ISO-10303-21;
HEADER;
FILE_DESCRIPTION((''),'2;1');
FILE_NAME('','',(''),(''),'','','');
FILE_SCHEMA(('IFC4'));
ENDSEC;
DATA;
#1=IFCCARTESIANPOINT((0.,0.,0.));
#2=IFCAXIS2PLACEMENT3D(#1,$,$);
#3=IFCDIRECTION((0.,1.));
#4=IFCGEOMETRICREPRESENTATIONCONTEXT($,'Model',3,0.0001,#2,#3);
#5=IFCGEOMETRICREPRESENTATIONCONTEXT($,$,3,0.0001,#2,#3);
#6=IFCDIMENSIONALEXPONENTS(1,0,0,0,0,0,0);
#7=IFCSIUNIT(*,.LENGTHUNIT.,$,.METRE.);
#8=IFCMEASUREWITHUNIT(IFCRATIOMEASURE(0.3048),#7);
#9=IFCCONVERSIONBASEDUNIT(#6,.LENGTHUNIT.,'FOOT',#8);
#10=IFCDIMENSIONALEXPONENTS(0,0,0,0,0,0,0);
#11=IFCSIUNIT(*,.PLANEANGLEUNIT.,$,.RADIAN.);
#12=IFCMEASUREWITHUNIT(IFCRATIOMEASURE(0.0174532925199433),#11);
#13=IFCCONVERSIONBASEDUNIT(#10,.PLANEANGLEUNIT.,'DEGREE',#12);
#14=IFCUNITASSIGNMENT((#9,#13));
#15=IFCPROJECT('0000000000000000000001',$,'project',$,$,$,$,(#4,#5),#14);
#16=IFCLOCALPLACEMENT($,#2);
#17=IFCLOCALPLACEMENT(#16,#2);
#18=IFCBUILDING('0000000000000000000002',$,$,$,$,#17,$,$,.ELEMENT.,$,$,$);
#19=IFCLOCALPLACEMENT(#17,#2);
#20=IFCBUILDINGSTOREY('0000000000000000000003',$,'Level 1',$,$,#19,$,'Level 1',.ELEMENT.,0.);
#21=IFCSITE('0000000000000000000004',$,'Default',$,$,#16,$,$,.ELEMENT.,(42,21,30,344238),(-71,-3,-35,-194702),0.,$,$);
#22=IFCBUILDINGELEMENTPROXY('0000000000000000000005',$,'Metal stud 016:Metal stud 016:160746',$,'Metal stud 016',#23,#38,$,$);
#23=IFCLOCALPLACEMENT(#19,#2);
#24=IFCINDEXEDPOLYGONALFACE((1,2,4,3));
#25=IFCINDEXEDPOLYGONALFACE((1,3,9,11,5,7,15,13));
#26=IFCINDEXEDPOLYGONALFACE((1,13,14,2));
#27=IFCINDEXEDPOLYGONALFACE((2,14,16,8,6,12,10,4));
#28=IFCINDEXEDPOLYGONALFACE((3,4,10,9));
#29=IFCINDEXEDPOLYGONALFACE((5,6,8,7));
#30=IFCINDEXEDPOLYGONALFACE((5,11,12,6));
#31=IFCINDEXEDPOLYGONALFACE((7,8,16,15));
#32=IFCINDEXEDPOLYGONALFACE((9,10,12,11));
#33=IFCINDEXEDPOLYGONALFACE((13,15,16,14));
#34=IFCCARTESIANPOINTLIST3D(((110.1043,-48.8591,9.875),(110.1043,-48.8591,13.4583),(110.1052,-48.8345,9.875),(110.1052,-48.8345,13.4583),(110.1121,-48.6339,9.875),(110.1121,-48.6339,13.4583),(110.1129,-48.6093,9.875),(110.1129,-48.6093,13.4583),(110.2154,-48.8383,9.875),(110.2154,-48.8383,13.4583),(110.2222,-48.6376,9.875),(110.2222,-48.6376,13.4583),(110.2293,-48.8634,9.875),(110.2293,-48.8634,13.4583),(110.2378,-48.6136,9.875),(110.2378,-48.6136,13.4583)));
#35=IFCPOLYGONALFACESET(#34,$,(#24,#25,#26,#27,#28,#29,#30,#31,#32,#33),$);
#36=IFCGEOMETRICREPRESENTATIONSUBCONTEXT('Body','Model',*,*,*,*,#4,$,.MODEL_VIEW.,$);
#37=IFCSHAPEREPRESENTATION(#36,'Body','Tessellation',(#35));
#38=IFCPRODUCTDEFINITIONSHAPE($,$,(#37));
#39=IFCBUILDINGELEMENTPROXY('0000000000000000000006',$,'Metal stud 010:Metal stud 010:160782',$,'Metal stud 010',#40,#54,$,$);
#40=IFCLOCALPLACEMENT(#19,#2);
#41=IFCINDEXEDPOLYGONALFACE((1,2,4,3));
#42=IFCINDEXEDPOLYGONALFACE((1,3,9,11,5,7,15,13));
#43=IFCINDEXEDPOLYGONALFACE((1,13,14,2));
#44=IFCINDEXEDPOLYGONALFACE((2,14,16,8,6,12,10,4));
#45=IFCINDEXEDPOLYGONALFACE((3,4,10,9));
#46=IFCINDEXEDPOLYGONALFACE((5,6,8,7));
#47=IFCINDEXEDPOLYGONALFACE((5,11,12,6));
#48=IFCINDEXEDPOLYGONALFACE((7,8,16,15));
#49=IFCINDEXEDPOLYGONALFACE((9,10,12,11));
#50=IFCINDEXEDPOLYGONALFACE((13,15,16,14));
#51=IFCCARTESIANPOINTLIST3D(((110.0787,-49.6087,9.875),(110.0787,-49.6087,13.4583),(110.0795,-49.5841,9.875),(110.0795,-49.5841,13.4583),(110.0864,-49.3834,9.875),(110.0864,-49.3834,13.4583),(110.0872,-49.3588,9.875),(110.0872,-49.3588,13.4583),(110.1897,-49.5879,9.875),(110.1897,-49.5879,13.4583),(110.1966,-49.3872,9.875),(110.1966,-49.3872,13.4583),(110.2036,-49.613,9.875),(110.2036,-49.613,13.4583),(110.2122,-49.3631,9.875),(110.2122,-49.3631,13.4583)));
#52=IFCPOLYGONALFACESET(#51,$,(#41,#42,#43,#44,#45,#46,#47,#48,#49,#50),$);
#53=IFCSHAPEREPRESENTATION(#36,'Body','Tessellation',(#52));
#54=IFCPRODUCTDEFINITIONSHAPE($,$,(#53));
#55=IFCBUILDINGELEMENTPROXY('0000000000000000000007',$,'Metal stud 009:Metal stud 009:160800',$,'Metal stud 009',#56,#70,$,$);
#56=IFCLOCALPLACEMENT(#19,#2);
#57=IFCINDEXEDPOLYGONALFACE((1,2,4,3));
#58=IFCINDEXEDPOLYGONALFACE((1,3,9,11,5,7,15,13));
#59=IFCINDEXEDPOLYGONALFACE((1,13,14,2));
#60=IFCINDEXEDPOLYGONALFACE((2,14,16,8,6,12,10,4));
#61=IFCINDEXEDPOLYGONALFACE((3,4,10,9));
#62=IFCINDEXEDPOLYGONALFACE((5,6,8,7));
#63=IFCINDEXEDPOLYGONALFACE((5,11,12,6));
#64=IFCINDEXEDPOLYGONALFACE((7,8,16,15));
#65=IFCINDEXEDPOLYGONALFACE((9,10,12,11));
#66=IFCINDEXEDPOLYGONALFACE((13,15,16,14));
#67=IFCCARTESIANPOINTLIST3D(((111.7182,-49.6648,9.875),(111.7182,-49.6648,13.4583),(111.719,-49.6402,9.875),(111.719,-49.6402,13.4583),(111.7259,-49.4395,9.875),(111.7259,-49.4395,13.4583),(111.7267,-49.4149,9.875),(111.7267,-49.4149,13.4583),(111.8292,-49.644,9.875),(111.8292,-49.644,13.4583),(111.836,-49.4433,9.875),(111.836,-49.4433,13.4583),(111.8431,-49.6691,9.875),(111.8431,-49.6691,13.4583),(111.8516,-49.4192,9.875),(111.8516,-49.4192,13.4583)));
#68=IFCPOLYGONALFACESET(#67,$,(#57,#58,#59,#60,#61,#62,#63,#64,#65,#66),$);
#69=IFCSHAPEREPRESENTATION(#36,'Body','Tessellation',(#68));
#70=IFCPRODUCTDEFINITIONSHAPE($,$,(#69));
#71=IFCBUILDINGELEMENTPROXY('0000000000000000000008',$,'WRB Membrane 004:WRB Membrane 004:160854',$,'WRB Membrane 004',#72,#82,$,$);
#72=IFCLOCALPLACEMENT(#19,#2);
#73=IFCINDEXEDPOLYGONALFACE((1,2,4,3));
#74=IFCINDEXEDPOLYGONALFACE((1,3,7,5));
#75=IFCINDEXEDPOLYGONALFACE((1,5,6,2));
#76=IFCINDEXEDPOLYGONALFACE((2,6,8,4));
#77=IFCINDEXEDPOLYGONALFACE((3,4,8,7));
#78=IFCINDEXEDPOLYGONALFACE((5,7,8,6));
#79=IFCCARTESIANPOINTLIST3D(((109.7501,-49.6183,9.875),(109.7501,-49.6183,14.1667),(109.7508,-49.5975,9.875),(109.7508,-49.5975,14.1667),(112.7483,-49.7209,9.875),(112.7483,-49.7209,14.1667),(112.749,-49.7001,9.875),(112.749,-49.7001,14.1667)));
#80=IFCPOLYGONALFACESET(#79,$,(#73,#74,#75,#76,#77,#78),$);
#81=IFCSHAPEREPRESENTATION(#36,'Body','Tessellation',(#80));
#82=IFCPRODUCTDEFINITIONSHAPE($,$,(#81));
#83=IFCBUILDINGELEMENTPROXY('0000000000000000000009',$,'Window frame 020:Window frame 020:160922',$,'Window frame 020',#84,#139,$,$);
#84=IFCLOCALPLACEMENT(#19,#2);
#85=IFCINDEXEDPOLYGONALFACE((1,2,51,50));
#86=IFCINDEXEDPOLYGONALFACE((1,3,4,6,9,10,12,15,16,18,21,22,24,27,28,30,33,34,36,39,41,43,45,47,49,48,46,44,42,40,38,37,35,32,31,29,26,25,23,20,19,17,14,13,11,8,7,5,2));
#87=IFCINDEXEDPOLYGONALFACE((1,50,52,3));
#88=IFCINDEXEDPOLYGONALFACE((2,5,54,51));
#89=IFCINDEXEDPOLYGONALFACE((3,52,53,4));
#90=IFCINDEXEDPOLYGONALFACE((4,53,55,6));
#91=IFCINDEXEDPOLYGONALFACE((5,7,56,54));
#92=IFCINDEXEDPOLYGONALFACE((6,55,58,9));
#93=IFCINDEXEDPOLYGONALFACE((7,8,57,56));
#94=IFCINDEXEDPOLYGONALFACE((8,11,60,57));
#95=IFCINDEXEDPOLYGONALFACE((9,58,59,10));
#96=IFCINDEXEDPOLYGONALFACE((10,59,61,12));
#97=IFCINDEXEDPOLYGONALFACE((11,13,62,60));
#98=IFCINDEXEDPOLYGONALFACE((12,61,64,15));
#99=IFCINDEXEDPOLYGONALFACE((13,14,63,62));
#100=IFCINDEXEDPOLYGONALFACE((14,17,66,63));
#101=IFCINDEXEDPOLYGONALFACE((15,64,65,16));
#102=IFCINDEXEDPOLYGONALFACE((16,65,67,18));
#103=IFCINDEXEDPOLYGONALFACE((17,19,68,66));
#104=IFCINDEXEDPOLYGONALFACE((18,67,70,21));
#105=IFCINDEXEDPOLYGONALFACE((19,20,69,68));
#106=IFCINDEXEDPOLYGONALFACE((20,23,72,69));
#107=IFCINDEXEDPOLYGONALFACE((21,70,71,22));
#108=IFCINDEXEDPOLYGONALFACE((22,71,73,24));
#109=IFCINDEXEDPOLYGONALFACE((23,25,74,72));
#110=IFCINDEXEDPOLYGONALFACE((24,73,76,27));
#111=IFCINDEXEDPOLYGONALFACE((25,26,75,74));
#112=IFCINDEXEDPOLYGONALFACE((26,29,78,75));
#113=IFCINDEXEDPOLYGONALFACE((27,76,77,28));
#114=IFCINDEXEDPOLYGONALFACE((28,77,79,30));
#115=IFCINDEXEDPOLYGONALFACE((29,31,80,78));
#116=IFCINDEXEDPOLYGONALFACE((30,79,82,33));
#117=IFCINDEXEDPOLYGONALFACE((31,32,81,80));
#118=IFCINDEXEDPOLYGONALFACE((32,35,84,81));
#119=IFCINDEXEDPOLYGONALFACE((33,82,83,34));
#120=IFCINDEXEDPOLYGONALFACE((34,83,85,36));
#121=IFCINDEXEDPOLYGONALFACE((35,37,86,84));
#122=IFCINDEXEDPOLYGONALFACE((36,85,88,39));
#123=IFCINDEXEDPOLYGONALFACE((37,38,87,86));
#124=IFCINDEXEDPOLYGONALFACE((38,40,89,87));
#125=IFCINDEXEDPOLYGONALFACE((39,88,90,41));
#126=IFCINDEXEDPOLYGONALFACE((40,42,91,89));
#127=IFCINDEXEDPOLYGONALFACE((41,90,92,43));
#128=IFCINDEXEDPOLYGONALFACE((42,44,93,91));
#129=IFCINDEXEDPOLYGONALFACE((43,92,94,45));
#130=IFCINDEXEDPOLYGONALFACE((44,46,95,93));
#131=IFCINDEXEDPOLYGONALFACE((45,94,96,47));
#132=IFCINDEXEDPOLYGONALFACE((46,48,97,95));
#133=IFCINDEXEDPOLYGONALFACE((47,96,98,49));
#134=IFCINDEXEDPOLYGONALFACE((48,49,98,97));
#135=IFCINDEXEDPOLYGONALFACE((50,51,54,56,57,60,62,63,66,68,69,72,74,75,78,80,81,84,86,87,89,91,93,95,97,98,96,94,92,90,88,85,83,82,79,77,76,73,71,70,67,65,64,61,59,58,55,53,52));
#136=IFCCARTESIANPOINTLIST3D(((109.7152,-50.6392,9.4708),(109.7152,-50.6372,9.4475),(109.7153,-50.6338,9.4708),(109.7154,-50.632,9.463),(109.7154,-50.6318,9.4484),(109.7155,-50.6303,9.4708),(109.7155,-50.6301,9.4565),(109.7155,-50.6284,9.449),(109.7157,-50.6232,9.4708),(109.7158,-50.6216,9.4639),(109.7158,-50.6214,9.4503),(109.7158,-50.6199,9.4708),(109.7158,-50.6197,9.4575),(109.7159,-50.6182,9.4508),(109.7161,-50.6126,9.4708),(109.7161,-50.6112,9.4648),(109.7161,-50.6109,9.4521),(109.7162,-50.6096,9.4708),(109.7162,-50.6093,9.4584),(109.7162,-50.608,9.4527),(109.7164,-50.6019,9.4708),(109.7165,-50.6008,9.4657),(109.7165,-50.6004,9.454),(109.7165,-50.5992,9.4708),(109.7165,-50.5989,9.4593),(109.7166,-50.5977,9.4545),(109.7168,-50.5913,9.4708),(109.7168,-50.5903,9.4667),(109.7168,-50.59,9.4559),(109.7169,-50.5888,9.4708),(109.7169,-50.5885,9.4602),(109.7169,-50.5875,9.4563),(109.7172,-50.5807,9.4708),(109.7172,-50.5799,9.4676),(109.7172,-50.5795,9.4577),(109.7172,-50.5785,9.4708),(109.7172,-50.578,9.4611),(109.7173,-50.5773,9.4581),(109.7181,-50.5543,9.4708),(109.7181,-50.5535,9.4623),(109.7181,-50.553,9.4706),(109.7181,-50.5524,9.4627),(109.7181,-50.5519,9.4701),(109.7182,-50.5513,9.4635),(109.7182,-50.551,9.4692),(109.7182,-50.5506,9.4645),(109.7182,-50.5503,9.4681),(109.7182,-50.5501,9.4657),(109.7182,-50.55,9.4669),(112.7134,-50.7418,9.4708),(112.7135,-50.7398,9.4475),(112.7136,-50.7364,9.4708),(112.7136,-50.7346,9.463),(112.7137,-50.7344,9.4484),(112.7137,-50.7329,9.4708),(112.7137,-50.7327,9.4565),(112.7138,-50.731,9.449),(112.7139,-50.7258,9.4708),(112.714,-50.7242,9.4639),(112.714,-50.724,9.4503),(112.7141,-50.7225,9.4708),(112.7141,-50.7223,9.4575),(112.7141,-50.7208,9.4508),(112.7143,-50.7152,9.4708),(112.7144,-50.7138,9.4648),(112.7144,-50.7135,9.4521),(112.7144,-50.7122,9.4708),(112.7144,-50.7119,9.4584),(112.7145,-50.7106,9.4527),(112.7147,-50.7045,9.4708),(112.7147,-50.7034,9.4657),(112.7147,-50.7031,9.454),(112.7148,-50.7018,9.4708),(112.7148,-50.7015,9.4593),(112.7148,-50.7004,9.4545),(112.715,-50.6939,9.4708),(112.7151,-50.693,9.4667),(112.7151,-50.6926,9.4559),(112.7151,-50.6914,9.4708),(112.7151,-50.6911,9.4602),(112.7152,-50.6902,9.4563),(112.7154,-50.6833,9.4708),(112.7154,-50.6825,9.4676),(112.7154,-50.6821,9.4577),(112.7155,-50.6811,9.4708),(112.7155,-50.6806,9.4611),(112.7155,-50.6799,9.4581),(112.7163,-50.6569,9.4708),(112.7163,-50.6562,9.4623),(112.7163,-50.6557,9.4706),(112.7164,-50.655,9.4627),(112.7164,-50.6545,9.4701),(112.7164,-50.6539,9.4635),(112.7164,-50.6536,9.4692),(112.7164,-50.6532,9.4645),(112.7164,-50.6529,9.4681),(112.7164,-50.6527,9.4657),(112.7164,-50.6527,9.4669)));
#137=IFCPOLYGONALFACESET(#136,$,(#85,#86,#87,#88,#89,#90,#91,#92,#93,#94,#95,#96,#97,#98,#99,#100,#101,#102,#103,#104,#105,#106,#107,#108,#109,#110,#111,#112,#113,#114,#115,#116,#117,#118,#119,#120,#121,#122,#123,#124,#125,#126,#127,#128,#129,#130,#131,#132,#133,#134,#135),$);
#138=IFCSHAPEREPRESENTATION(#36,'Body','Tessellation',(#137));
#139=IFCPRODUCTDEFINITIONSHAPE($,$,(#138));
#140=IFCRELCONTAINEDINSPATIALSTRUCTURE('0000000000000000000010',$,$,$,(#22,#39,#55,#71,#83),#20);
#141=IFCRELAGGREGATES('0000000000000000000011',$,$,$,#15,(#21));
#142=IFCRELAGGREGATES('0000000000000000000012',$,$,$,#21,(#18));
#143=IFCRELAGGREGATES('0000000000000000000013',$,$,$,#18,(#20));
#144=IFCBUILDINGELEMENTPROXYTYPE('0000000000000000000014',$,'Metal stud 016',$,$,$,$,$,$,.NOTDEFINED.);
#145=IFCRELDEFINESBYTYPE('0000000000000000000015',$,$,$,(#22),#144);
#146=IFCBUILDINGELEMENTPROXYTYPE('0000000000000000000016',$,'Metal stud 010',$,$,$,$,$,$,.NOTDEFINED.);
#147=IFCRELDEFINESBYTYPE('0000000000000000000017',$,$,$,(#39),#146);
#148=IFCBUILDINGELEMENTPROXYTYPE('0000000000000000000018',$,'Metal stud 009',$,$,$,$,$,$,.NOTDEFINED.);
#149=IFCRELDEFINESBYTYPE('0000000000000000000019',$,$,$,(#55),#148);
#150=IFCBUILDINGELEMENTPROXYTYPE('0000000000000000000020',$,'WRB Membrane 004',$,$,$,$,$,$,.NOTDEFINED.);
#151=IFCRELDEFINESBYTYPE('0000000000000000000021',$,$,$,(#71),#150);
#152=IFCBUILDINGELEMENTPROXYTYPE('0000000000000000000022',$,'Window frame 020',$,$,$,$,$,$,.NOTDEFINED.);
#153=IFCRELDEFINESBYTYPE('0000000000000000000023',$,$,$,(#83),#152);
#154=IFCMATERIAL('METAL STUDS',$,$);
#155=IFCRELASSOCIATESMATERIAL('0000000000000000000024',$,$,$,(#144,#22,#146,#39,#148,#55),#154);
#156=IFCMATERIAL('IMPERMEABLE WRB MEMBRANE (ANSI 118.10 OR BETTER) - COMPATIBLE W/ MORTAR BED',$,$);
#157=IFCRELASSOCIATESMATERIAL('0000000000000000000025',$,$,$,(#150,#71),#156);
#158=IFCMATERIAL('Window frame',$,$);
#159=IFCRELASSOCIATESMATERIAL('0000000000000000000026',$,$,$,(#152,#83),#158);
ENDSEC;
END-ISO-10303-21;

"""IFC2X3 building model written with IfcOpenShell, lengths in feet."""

from ifc_helpers import new_model, entity, si_unit, converted_unit, direction, frame, frame_2d, origin, origin_2d_with_axis, place, context, subcontext, project, spatial, polyline, circle_curve, parameter, trimmed, segment, composite_curve, rectangle, outline, extrude, source, transform, mapped, material, type_object, type_shapes, element, save


model = new_model("IFC2X3")

# Units and contexts
model_context = context("Model", 3, precision=0.0001, world=origin(), true_north=direction((0.0, 1.0)))
context_of_model = context(None, 3, precision=0.0001, world=origin(), true_north=direction((0.0, 1.0)))
body_context = subcontext(model_context, "Body", "Model", "MODEL_VIEW")
ifc_project = project(units=[converted_unit("LENGTHUNIT", "FOOT", entity("IfcRatioMeasure", 0.3048), si_unit("LENGTHUNIT", "METRE"), dimensions=[1, 0, 0, 0, 0, 0, 0]), converted_unit("PLANEANGLEUNIT", "DEGREE", entity("IfcRatioMeasure", 0.0174532925199433), si_unit("PLANEANGLEUNIT", "RADIAN"), dimensions=[0, 0, 0, 0, 0, 0, 0])], contexts=[model_context, context_of_model])

# Site, building, storey
site_placement = place(None, origin())
site = spatial("IfcSite", under=ifc_project, at=site_placement, Name="Default", CompositionType="ELEMENT", RefLatitude=(42, 21, 30, 344238), RefLongitude=(-71, -3, -35, -194702), RefElevation=0.0)
building_placement = place(site_placement, origin())
building = spatial("IfcBuilding", under=site, at=building_placement, CompositionType="ELEMENT")
storey_placement = place(building_placement, origin())
storey = spatial("IfcBuildingStorey", under=building, at=storey_placement, Name="Level 1", LongName="Level 1", CompositionType="ELEMENT", Elevation=0.0)

# Building element proxies
ifc_material_1 = material(Name="METAL STUDS")
building_element_proxy_type_1 = type_object("IfcBuildingElementProxyType", Name="Metal stud 016", PredefinedType="NOTDEFINED", material=ifc_material_1)
shared_shape_1 = source(origin(), body_context, "Body", "SweptSolid", [
    extrude(outline(polyline([(-0.0662, -0.125), (0.0588, -0.125), (0.0588, -0.1004), (-0.0514, -0.1004), (-0.0514, 0.1004), (0.0588, 0.1004), (0.0588, 0.125), (-0.0662, 0.125), (-0.0662, -0.125)])), frame((110.1674, -48.7362, 9.875), z_axis=(0.0, 0.0, 1.0), x_axis=(-0.999415, 0.034202, 0.0)), (0.0, 0.0, 1.0), 3.5833),
])
type_shapes(building_element_proxy_type_1, [shared_shape_1])
proxy_1_placement = place(storey_placement, origin())
element("IfcBuildingElementProxy", 1, at=proxy_1_placement, inside=storey, type_object=building_element_proxy_type_1, material=ifc_material_1, Name="Metal stud 016:Metal stud 016:160746", ObjectType="Metal stud 016", context=body_context, shape_type="MappedRepresentation", body=[
    mapped(shared_shape_1, transform((0.0, 0.0, 0.0), scale=1.0)),
])
building_element_proxy_type_2 = type_object("IfcBuildingElementProxyType", Name="Metal stud 010", PredefinedType="NOTDEFINED", material=ifc_material_1)
shared_shape_2 = source(origin(), body_context, "Body", "SweptSolid", [
    extrude(outline(polyline([(-0.0662, -0.125), (0.0588, -0.125), (0.0588, -0.1004), (-0.0514, -0.1004), (-0.0514, 0.1004), (0.0588, 0.1004), (0.0588, 0.125), (-0.0662, 0.125), (-0.0662, -0.125)])), frame((110.1417, -49.4858, 9.875), z_axis=(0.0, 0.0, 1.0), x_axis=(-0.999415, 0.034202, 0.0)), (0.0, 0.0, 1.0), 3.5833),
])
type_shapes(building_element_proxy_type_2, [shared_shape_2])
proxy_2_placement = place(storey_placement, origin())
element("IfcBuildingElementProxy", 2, at=proxy_2_placement, inside=storey, type_object=building_element_proxy_type_2, material=ifc_material_1, Name="Metal stud 010:Metal stud 010:160782", ObjectType="Metal stud 010", context=body_context, shape_type="MappedRepresentation", body=[
    mapped(shared_shape_2, transform((0.0, 0.0, 0.0), scale=1.0)),
])
building_element_proxy_type_3 = type_object("IfcBuildingElementProxyType", Name="Metal stud 009", PredefinedType="NOTDEFINED", material=ifc_material_1)
shared_shape_3 = source(origin(), body_context, "Body", "SweptSolid", [
    extrude(outline(polyline([(-0.0662, -0.125), (0.0588, -0.125), (0.0588, -0.1004), (-0.0514, -0.1004), (-0.0514, 0.1004), (0.0588, 0.1004), (0.0588, 0.125), (-0.0662, 0.125), (-0.0662, -0.125)])), frame((111.7812, -49.5419, 9.875), z_axis=(0.0, 0.0, 1.0), x_axis=(-0.999415, 0.034202, 0.0)), (0.0, 0.0, 1.0), 3.5833),
])
type_shapes(building_element_proxy_type_3, [shared_shape_3])
proxy_3_placement = place(storey_placement, origin())
element("IfcBuildingElementProxy", 3, at=proxy_3_placement, inside=storey, type_object=building_element_proxy_type_3, material=ifc_material_1, Name="Metal stud 009:Metal stud 009:160800", ObjectType="Metal stud 009", context=body_context, shape_type="MappedRepresentation", body=[
    mapped(shared_shape_3, transform((0.0, 0.0, 0.0), scale=1.0)),
])
ifc_material_2 = material(Name="IMPERMEABLE WRB MEMBRANE (ANSI 118.10 OR BETTER) - COMPATIBLE W/ MORTAR BED")
building_element_proxy_type_4 = type_object("IfcBuildingElementProxyType", Name="WRB Membrane 004", PredefinedType="NOTDEFINED", material=ifc_material_2)
shared_shape_4 = source(origin(), body_context, "Body", "SweptSolid", [
    extrude(rectangle(XDim=3.0, YDim=0.0208, at=origin_2d_with_axis()), frame((111.2496, -49.6592, 9.875), z_axis=(0.0, 0.0, 1.0), x_axis=(-0.999415, 0.034202, 0.0)), (0.0, 0.0, 1.0), 4.2917),
])
type_shapes(building_element_proxy_type_4, [shared_shape_4])
proxy_4_placement = place(storey_placement, origin())
element("IfcBuildingElementProxy", 4, at=proxy_4_placement, inside=storey, type_object=building_element_proxy_type_4, material=ifc_material_2, Name="WRB Membrane 004:WRB Membrane 004:160854", ObjectType="WRB Membrane 004", context=body_context, shape_type="MappedRepresentation", body=[
    mapped(shared_shape_4, transform((0.0, 0.0, 0.0), scale=1.0)),
])
ifc_material_3 = material(Name="Window frame")
building_element_proxy_type_5 = type_object("IfcBuildingElementProxyType", Name="Window frame 020", PredefinedType="NOTDEFINED", material=ifc_material_3)
shared_shape_5 = source(origin(), body_context, "Body", "SweptSolid", [
    extrude(outline(composite_curve([segment(polyline([(-0.0351, -0.0087), (-0.0297, -0.0087)]), True, "CONTINUOUS"), segment(polyline([(-0.0297, -0.0087), (-0.0266, -0.001)]), True, "CONTINUOUS"), segment(polyline([(-0.0266, -0.001), (-0.0262, -0.0087)]), True, "CONTINUOUS"), segment(polyline([(-0.0262, -0.0087), (-0.0191, -0.0087)]), True, "CONTINUOUS"), segment(polyline([(-0.0191, -0.0087), (-0.0161, -0.0019)]), True, "CONTINUOUS"), segment(polyline([(-0.0161, -0.0019), (-0.0158, -0.0087)]), True, "CONTINUOUS"), segment(polyline([(-0.0158, -0.0087), (-0.0084, -0.0087)]), True, "CONTINUOUS"), segment(polyline([(-0.0084, -0.0087), (-0.0057, -0.0028)]), True, "CONTINUOUS"), segment(polyline([(-0.0057, -0.0028), (-0.0054, -0.0087)]), True, "CONTINUOUS"), segment(polyline([(-0.0054, -0.0087), (0.0022, -0.0087)]), True, "CONTINUOUS"), segment(polyline([(0.0022, -0.0087), (0.0047, -0.0037)]), True, "CONTINUOUS"), segment(polyline([(0.0047, -0.0037), (0.0049, -0.0087)]), True, "CONTINUOUS"), segment(polyline([(0.0049, -0.0087), (0.0128, -0.0087)]), True, "CONTINUOUS"), segment(polyline([(0.0128, -0.0087), (0.0151, -0.0046)]), True, "CONTINUOUS"), segment(polyline([(0.0151, -0.0046), (0.0153, -0.0087)]), True, "CONTINUOUS"), segment(polyline([(0.0153, -0.0087), (0.0235, -0.0087)]), True, "CONTINUOUS"), segment(polyline([(0.0235, -0.0087), (0.0255, -0.0056)]), True, "CONTINUOUS"), segment(polyline([(0.0255, -0.0056), (0.0257, -0.0087)]), True, "CONTINUOUS"), segment(polyline([(0.0257, -0.0087), (0.0499, -0.0087)]), True, "CONTINUOUS"), segment(trimmed(circle_curve(frame_2d((0.0499, -0.0044), x_axis=(-0.984549, 0.175111)), 0.0043), [parameter(100.085127)], [parameter(269.994873)], True, "PARAMETER"), True, "CONTINUOUS"), segment(polyline([(0.0506, -0.0002), (0.0268, 0.004)]), True, "CONTINUOUS"), segment(polyline([(0.0268, 0.004), (0.0248, 0.0011)]), True, "CONTINUOUS"), segment(polyline([(0.0248, 0.0011), (0.0246, 0.0044)]), True, "CONTINUOUS"), segment(polyline([(0.0246, 0.0044), (0.0166, 0.0058)]), True, "CONTINUOUS"), segment(polyline([(0.0166, 0.0058), (0.0144, 0.002)]), True, "CONTINUOUS"), segment(polyline([(0.0144, 0.002), (0.0142, 0.0063)]), True, "CONTINUOUS"), segment(polyline([(0.0142, 0.0063), (0.0064, 0.0077)]), True, "CONTINUOUS"), segment(polyline([(0.0064, 0.0077), (0.004, 0.003)]), True, "CONTINUOUS"), segment(polyline([(0.004, 0.003), (0.0037, 0.0081)]), True, "CONTINUOUS"), segment(polyline([(0.0037, 0.0081), (-0.0038, 0.0095)]), True, "CONTINUOUS"), segment(polyline([(-0.0038, 0.0095), (-0.0065, 0.0039)]), True, "CONTINUOUS"), segment(polyline([(-0.0065, 0.0039), (-0.0068, 0.01)]), True, "CONTINUOUS"), segment(polyline([(-0.0068, 0.01), (-0.014, 0.0113)]), True, "CONTINUOUS"), segment(polyline([(-0.014, 0.0113), (-0.0169, 0.0048)]), True, "CONTINUOUS"), segment(polyline([(-0.0169, 0.0048), (-0.0172, 0.0119)]), True, "CONTINUOUS"), segment(polyline([(-0.0172, 0.0119), (-0.0242, 0.0131)]), True, "CONTINUOUS"), segment(polyline([(-0.0242, 0.0131), (-0.0273, 0.0057)]), True, "CONTINUOUS"), segment(polyline([(-0.0273, 0.0057), (-0.0277, 0.0137)]), True, "CONTINUOUS"), segment(polyline([(-0.0277, 0.0137), (-0.0331, 0.0147)]), True, "CONTINUOUS"), segment(polyline([(-0.0331, 0.0147), (-0.0351, -0.0087)]), True, "CONTINUOUS")], self_intersect=False)), frame((109.7164, -50.6041, 9.4621), z_axis=(0.999415, -0.034202, 0.0), x_axis=(0.033673, 0.983973, 0.175111)), (0.0, 0.0, 1.0), 3.0),
])
type_shapes(building_element_proxy_type_5, [shared_shape_5])
proxy_5_placement = place(storey_placement, origin())
element("IfcBuildingElementProxy", 5, at=proxy_5_placement, inside=storey, type_object=building_element_proxy_type_5, material=ifc_material_3, Name="Window frame 020:Window frame 020:160922", ObjectType="Window frame 020", context=body_context, shape_type="MappedRepresentation", body=[
    mapped(shared_shape_5, transform((0.0, 0.0, 0.0), scale=1.0)),
])

save(model, "model.ifc")
